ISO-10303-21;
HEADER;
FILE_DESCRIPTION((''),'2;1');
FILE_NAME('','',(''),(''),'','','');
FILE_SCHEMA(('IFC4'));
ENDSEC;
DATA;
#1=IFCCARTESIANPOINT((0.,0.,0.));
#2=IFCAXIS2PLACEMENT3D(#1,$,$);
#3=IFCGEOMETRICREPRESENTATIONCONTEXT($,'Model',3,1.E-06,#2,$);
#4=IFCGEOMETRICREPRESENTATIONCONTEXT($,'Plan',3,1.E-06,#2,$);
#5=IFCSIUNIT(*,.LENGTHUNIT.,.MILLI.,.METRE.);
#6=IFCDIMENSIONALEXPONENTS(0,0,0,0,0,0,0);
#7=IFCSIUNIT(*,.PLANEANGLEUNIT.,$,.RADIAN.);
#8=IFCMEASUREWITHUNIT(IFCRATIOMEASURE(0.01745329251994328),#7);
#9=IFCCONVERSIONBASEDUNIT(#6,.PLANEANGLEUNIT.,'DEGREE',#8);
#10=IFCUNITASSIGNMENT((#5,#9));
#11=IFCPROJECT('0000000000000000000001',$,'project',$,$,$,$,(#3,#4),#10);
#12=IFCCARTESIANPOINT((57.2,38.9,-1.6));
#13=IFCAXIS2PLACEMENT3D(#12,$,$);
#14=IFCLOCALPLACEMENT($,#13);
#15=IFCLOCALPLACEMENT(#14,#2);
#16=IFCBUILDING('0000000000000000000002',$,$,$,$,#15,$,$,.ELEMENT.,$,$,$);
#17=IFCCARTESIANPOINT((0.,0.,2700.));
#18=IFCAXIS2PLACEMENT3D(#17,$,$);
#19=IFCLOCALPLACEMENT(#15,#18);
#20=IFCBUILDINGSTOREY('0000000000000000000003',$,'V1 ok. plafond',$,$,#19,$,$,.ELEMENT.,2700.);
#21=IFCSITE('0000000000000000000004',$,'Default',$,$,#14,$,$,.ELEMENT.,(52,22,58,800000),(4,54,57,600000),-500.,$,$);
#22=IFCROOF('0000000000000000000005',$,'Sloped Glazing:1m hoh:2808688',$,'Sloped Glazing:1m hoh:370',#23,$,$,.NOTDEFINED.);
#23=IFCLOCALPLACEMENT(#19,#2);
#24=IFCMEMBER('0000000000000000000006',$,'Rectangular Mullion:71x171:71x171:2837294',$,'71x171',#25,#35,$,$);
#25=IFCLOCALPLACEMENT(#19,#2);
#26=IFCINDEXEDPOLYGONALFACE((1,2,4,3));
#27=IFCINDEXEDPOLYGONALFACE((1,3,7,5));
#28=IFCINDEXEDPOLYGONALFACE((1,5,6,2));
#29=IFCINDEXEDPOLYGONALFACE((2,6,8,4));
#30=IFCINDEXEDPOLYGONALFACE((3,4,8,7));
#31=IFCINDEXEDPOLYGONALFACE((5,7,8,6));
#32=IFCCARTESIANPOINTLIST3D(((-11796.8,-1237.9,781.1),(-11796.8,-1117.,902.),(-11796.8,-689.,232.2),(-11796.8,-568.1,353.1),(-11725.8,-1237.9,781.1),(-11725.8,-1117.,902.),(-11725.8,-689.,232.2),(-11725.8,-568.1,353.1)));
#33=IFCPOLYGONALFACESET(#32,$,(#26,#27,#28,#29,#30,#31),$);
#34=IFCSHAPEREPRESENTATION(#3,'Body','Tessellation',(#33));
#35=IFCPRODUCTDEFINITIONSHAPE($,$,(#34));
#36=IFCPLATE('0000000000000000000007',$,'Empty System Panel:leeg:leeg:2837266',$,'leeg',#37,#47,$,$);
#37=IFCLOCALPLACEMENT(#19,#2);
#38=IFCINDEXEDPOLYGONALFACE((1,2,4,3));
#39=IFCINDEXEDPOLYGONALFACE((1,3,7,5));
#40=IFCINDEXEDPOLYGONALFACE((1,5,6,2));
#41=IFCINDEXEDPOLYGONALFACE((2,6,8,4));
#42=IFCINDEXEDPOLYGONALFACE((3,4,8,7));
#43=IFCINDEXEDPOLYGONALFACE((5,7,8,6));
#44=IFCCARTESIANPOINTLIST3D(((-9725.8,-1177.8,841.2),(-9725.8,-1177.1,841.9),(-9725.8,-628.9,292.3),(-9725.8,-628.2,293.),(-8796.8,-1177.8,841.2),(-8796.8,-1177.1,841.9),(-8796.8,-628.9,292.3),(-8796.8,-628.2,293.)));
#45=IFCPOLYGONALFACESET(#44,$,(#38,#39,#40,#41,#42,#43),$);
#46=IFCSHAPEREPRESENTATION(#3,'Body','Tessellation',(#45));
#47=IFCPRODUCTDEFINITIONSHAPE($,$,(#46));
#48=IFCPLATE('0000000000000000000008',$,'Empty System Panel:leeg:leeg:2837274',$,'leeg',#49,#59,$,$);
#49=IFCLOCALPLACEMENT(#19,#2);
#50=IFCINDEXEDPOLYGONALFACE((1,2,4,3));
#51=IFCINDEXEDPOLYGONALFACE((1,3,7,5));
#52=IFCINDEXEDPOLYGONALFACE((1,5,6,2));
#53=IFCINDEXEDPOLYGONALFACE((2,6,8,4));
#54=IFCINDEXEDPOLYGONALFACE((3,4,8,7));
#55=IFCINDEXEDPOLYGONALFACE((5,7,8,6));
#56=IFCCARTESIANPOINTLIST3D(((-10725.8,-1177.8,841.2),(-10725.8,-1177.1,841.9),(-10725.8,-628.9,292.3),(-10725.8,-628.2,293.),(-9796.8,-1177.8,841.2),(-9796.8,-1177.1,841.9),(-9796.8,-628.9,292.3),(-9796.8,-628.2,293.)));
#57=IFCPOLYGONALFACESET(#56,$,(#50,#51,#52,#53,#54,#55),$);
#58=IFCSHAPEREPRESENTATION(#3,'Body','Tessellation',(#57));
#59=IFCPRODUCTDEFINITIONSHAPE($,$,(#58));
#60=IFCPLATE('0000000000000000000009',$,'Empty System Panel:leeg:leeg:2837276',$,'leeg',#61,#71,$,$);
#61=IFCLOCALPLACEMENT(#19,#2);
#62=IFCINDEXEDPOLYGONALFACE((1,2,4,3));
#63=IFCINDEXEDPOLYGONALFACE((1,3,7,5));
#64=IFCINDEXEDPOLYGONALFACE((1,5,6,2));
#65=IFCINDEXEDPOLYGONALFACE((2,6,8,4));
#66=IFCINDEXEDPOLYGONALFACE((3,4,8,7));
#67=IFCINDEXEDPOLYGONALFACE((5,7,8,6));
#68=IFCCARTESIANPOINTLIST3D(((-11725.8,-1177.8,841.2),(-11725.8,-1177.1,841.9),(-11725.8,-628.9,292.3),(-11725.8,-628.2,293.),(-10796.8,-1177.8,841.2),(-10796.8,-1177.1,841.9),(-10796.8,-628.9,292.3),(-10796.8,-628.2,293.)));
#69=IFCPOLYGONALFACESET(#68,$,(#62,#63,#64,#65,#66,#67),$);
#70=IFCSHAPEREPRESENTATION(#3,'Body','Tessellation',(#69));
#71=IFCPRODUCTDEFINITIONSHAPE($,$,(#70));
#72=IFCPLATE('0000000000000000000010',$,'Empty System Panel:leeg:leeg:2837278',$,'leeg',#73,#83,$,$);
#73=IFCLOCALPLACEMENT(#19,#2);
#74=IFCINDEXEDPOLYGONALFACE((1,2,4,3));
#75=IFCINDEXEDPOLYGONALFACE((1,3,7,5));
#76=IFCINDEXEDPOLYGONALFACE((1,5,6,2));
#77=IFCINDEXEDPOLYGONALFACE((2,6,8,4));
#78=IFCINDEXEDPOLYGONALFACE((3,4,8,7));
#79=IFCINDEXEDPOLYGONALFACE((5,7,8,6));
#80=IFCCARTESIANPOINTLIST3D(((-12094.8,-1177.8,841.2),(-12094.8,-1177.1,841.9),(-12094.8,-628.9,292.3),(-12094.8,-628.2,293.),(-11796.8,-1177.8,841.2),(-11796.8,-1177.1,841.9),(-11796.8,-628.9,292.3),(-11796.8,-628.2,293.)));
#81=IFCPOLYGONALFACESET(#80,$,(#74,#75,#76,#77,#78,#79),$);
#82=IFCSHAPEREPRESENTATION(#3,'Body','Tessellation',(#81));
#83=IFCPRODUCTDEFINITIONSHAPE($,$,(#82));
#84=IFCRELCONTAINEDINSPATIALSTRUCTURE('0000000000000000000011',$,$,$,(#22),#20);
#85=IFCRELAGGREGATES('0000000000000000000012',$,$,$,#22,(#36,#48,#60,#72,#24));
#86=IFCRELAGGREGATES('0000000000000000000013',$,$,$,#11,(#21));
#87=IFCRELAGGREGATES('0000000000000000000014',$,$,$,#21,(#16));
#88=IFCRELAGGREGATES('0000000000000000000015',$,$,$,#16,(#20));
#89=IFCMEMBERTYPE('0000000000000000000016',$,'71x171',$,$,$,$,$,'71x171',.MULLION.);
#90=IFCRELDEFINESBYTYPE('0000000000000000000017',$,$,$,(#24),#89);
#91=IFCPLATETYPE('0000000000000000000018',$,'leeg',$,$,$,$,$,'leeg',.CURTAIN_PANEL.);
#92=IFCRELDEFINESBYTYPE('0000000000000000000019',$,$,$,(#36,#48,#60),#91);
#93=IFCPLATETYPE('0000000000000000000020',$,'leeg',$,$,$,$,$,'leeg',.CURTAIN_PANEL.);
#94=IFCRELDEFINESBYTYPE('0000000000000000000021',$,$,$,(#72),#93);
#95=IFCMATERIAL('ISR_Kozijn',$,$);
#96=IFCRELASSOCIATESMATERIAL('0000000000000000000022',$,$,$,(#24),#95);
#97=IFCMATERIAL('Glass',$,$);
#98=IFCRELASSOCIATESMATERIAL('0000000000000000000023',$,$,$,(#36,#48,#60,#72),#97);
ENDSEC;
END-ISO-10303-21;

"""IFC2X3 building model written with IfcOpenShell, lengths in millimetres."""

from ifc_helpers import new_model, entity, si_unit, converted_unit, frame, origin, origin_2d_with_axis, place, context, project, spatial, rectangle, extrude, source, transform, mapped, material, type_object, type_shapes, element, aggregate, save


model = new_model("IFC2X3")

# Units and contexts
model_context = context("Model", 3, precision=1e-06, world=origin())
plan_context = context("Plan", 3, precision=1e-06, world=origin())
ifc_project = project(units=[si_unit("LENGTHUNIT", "METRE", prefix="MILLI"), converted_unit("PLANEANGLEUNIT", "DEGREE", entity("IfcRatioMeasure", 0.01745329251994328), si_unit("PLANEANGLEUNIT", "RADIAN"), dimensions=[0, 0, 0, 0, 0, 0, 0])], contexts=[model_context, plan_context])

# Site, building, storey
site_placement = place(None, frame((57.2, 38.9, -1.6)))
site = spatial("IfcSite", under=ifc_project, at=site_placement, Name="Default", CompositionType="ELEMENT", RefLatitude=(52, 22, 58, 800000), RefLongitude=(4, 54, 57, 600000), RefElevation=-500.0)
building_placement = place(site_placement, origin())
building = spatial("IfcBuilding", under=site, at=building_placement, CompositionType="ELEMENT")
storey_placement = place(building_placement, frame((0.0, 0.0, 2700.0)))
storey = spatial("IfcBuildingStorey", under=building, at=storey_placement, Name="V1 ok. plafond", CompositionType="ELEMENT", Elevation=2700.0)

# Roof, member, plates
roof_placement = place(storey_placement, origin())
roof = element("IfcRoof", 1, at=roof_placement, inside=storey, Name="Sloped Glazing:1m hoh:2808688", ObjectType="Sloped Glazing:1m hoh:370", ShapeType="NOTDEFINED")
ifc_material_1 = material(Name="ISR_Kozijn")
placement = place(building_placement, frame((0.0, 0.0, 2970.0)))
member_type_1 = type_object("IfcMemberType", Name="71x171", ElementType="71x171", PredefinedType="MULLION")
shared_shape_1 = source(origin(), model_context, "Body", "SweptSolid", [
    extrude(rectangle(XDim=71.0, YDim=171.0, at=origin_2d_with_axis()), frame((0.0, 0.0, -776.2), z_axis=(0.0, 0.0, 1.0), x_axis=(-1.0, 0.0, 0.0)), (0.0, 0.0, 1.0), 776.2),
])
type_shapes(member_type_1, [shared_shape_1])
member_1_placement = place(placement, frame((-11761.3, -1177.4, 571.5), z_axis=(0.0, -0.707107, 0.707107), x_axis=(-1.0, 0.0, 0.0)))
member_1 = element("IfcMember", 2, at=member_1_placement, type_object=member_type_1, material=ifc_material_1, Name="Rectangular Mullion:71x171:71x171:2837294", ObjectType="71x171", context=model_context, shape_type="MappedRepresentation", body=[
    mapped(shared_shape_1, transform((0.0, 0.0, 0.0), scale=1.0)),
])
ifc_material_2 = material(Name="Glass")
plate_type_1 = type_object("IfcPlateType", Name="leeg", ElementType="leeg", PredefinedType="CURTAIN_PANEL")
shared_shape_2 = source(origin(), model_context, "Body", "SweptSolid", [
    extrude(rectangle(XDim=1.0, YDim=929.0, at=origin_2d_with_axis()), frame((0.0, 0.0, 0.0), z_axis=(0.0, 0.0, 1.0), x_axis=(0.0, 1.0, 0.0)), (0.0, 0.0, 1.0), 776.2),
])
type_shapes(plate_type_1, [shared_shape_2])
plate_1_placement = place(placement, frame((-9261.3, -628.6, 22.6), z_axis=(0.0, -0.707107, 0.707107), x_axis=(-1.0, 0.0, 0.0)))
plate_1 = element("IfcPlate", 3, at=plate_1_placement, type_object=plate_type_1, material=ifc_material_2, Name="Empty System Panel:leeg:leeg:2837266", ObjectType="leeg", context=model_context, shape_type="MappedRepresentation", body=[
    mapped(shared_shape_2, transform((0.0, 0.0, 0.0), scale=1.0)),
])
plate_2_placement = place(placement, frame((-10261.3, -628.6, 22.6), z_axis=(0.0, -0.707107, 0.707107), x_axis=(-1.0, 0.0, 0.0)))
plate_2 = element("IfcPlate", 4, at=plate_2_placement, type_object=plate_type_1, material=ifc_material_2, Name="Empty System Panel:leeg:leeg:2837274", ObjectType="leeg", context=model_context, shape_type="MappedRepresentation", body=[
    mapped(shared_shape_2, transform((0.0, 0.0, 0.0), scale=1.0)),
])
plate_3_placement = place(placement, frame((-11261.3, -628.6, 22.6), z_axis=(0.0, -0.707107, 0.707107), x_axis=(-1.0, 0.0, 0.0)))
plate_3 = element("IfcPlate", 5, at=plate_3_placement, type_object=plate_type_1, material=ifc_material_2, Name="Empty System Panel:leeg:leeg:2837276", ObjectType="leeg", context=model_context, shape_type="MappedRepresentation", body=[
    mapped(shared_shape_2, transform((0.0, 0.0, 0.0), scale=1.0)),
])
plate_type_2 = type_object("IfcPlateType", Name="leeg", ElementType="leeg", PredefinedType="CURTAIN_PANEL")
shared_shape_3 = source(origin(), model_context, "Body", "SweptSolid", [
    extrude(rectangle(XDim=1.0, YDim=298.0, at=origin_2d_with_axis()), frame((0.0, 0.0, 0.0), z_axis=(0.0, 0.0, 1.0), x_axis=(0.0, 1.0, 0.0)), (0.0, 0.0, 1.0), 776.2),
])
type_shapes(plate_type_2, [shared_shape_3])
plate_4_placement = place(placement, frame((-11945.8, -628.6, 22.6), z_axis=(0.0, -0.707107, 0.707107), x_axis=(-1.0, 0.0, 0.0)))
plate_4 = element("IfcPlate", 6, at=plate_4_placement, type_object=plate_type_2, material=ifc_material_2, Name="Empty System Panel:leeg:leeg:2837278", ObjectType="leeg", context=model_context, shape_type="MappedRepresentation", body=[
    mapped(shared_shape_3, transform((0.0, 0.0, 0.0), scale=1.0)),
])
aggregate(roof, [plate_1, plate_2, plate_3, plate_4, member_1])

save(model, "model.ifc")
